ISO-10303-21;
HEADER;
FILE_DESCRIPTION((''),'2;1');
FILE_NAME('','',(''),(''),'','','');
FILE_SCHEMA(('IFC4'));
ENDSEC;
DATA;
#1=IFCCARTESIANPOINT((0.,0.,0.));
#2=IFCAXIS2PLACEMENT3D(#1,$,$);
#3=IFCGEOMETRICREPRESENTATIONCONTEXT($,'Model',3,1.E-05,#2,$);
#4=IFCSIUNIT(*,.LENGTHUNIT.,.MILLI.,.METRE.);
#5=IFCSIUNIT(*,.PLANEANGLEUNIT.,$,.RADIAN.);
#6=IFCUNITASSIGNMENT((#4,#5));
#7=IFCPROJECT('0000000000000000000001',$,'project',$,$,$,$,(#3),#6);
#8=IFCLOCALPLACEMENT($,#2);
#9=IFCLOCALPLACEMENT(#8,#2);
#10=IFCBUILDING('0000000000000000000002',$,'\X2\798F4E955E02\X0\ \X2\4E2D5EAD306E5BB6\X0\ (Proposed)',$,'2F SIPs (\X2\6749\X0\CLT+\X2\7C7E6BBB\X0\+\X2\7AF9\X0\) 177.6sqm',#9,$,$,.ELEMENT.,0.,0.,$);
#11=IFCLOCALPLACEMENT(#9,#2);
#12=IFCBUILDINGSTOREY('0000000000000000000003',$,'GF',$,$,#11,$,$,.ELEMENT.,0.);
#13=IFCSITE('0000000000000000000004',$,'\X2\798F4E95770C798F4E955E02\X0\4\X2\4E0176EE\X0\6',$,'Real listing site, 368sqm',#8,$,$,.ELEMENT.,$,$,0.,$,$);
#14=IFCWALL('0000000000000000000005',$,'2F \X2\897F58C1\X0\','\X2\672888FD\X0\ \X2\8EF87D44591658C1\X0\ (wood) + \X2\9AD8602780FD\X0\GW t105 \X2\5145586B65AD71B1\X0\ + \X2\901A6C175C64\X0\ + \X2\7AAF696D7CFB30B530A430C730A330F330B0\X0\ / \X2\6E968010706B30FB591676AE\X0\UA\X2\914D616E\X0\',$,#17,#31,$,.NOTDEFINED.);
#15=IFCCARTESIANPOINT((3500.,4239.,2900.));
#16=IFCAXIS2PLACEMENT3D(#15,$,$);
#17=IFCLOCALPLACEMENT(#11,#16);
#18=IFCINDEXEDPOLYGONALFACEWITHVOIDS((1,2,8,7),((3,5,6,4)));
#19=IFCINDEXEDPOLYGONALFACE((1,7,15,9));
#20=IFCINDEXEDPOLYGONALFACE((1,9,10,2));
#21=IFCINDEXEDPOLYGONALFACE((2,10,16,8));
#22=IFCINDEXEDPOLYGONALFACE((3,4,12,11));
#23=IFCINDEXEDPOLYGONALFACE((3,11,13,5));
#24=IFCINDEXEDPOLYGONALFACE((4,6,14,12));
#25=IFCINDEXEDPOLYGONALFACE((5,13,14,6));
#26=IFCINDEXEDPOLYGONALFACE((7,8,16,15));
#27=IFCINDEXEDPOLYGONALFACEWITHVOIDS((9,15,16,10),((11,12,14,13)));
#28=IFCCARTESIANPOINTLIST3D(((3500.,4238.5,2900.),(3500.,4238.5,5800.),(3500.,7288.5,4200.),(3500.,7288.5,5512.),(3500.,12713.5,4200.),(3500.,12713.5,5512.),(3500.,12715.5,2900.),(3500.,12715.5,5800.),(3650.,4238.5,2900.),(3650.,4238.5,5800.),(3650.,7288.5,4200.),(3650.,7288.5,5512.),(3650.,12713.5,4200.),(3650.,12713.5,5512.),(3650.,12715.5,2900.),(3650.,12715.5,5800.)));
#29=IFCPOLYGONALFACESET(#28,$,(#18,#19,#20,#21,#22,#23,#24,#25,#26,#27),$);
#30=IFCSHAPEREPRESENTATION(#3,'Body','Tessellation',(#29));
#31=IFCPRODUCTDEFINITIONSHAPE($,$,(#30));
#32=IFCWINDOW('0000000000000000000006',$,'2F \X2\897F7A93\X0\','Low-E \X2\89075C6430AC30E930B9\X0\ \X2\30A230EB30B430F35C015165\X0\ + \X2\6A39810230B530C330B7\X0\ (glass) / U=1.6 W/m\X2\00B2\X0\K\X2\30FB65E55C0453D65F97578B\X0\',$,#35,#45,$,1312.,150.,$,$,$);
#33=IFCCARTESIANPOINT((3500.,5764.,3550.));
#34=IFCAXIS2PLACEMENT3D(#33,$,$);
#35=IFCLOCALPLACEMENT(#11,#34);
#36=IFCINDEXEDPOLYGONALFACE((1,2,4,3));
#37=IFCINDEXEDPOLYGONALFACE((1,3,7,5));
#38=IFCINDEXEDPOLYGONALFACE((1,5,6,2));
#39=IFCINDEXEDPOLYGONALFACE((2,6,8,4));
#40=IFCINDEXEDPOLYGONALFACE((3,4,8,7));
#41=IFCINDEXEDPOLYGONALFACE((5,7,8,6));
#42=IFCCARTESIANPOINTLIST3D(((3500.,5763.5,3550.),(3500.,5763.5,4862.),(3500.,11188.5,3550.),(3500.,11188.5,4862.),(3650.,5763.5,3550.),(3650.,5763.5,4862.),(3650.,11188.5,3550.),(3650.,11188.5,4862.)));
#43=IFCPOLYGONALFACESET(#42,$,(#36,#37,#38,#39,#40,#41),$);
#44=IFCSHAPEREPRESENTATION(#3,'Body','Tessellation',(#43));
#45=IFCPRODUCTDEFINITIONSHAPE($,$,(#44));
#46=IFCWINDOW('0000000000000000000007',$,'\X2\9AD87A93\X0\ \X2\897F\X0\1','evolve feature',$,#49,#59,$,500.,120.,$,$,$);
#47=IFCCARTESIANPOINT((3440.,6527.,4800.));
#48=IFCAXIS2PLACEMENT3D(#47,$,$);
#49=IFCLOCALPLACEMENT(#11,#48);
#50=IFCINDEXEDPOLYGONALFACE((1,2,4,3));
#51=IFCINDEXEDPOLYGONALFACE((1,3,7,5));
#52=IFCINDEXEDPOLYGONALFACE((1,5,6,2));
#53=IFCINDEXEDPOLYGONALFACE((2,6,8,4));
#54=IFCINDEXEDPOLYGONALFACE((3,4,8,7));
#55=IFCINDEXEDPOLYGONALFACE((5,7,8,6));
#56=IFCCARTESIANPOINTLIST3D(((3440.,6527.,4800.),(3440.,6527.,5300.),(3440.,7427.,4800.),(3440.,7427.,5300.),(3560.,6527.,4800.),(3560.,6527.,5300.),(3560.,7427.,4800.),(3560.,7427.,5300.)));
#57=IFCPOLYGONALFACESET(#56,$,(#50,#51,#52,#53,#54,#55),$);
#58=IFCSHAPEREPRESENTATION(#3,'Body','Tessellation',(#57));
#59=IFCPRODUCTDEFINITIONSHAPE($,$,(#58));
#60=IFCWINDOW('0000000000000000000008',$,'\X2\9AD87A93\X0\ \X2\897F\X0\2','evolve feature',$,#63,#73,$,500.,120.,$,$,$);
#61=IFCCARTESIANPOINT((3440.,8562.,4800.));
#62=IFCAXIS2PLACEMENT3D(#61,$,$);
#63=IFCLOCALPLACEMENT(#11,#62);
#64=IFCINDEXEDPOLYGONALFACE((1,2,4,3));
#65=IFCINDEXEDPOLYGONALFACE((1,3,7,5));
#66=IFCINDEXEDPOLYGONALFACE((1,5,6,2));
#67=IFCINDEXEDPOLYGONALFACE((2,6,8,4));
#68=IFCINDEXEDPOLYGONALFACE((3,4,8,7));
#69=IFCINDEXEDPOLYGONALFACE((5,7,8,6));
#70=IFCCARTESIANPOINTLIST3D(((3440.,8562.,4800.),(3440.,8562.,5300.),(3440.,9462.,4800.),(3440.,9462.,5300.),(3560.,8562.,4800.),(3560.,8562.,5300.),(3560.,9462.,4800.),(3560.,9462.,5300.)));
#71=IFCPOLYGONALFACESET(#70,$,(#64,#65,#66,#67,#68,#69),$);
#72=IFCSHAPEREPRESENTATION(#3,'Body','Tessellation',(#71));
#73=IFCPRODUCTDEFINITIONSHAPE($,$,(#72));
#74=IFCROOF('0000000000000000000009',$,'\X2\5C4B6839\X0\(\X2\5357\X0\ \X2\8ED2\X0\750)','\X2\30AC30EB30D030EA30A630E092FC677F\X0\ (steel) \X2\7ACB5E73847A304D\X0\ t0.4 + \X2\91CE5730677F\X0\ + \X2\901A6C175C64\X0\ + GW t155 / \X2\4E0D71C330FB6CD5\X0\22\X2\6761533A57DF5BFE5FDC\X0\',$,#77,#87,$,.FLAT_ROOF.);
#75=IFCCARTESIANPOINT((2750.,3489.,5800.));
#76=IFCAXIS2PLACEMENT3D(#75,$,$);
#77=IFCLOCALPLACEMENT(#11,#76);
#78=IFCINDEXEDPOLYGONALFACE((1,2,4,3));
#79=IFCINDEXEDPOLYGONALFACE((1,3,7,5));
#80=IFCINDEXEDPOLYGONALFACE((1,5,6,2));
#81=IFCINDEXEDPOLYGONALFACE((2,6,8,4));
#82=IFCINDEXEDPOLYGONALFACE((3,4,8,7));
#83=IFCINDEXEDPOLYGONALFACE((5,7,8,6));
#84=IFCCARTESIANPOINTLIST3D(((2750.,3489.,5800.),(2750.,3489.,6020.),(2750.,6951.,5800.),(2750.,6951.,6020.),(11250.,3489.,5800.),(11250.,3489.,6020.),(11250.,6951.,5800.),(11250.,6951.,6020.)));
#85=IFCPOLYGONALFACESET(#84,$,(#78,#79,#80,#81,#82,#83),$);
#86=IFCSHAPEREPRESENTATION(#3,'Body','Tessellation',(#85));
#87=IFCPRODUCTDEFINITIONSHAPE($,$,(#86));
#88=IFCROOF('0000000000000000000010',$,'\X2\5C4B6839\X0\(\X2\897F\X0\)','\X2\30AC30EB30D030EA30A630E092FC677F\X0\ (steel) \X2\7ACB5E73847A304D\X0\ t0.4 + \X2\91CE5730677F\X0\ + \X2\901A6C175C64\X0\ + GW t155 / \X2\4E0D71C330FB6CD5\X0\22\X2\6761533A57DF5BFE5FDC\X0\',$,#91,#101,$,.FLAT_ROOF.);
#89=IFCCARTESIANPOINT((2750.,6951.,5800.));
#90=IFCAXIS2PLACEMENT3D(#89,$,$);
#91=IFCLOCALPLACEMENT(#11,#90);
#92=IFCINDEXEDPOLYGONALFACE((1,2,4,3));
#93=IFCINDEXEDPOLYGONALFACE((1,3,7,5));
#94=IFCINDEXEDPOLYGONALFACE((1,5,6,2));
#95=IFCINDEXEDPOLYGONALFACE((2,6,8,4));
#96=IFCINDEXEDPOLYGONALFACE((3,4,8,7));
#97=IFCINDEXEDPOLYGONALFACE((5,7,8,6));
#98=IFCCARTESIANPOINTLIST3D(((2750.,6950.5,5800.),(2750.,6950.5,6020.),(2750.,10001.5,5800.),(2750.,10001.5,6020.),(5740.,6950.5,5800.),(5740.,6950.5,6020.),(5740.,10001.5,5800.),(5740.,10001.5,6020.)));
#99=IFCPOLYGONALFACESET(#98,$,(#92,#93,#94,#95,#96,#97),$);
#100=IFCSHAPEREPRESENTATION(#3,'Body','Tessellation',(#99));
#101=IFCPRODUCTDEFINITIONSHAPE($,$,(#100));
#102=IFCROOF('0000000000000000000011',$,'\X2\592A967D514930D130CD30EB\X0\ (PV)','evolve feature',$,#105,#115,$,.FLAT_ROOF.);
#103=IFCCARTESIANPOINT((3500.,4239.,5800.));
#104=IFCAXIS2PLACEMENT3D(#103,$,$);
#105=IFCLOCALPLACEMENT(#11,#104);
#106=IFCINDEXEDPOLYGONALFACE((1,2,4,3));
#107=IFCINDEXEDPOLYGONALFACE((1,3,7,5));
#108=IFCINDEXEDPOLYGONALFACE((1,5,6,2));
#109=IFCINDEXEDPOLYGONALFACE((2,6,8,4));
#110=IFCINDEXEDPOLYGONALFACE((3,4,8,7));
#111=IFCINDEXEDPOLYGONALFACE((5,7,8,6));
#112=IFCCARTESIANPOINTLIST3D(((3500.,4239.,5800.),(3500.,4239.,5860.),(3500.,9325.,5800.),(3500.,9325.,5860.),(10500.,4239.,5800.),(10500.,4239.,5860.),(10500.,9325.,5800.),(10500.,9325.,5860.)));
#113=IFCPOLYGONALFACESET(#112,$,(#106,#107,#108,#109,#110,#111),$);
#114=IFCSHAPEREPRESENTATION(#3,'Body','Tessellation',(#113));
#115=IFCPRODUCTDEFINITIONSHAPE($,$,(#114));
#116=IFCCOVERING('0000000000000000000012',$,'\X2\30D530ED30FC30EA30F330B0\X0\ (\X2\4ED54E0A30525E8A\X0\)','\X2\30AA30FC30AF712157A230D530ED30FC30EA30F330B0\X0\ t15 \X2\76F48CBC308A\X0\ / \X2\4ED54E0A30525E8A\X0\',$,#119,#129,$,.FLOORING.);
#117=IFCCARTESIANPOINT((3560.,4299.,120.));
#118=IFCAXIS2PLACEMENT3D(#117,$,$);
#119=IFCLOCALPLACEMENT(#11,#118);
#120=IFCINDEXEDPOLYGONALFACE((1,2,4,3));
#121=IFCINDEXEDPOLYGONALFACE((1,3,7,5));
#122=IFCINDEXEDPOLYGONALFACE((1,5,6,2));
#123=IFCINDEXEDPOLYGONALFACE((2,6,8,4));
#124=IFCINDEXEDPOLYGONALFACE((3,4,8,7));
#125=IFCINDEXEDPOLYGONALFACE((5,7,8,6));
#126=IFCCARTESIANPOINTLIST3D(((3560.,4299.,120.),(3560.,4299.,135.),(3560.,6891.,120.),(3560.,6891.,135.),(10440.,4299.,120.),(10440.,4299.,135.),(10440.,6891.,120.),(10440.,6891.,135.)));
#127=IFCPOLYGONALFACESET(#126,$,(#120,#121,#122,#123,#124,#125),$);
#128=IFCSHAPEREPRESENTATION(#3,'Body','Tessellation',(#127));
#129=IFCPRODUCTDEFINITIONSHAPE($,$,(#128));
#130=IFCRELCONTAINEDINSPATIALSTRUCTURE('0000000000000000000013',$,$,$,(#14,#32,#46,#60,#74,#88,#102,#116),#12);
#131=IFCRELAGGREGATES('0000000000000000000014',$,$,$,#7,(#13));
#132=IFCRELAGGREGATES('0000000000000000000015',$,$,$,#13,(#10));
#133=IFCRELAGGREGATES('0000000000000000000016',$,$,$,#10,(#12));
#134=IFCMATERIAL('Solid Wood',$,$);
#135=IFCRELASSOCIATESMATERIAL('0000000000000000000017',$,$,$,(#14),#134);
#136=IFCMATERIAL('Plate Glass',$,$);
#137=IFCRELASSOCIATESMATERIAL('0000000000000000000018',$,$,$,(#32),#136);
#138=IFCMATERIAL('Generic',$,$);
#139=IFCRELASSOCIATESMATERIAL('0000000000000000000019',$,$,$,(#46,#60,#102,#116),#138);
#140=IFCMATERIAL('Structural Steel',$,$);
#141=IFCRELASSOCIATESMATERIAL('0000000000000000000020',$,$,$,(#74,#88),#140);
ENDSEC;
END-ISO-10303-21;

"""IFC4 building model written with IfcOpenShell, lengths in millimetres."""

from ifc_helpers import new_model, si_unit, frame, frame_2d, origin, place, context, project, spatial, rectangle, extrude, material, element, fill, save


model = new_model("IFC4")

# Units and contexts
model_context = context("Model", 3, precision=1e-05, world=origin())
ifc_project = project(units=[si_unit("LENGTHUNIT", "METRE", prefix="MILLI"), si_unit("PLANEANGLEUNIT", "RADIAN")], contexts=[model_context])

# Site, building, storey
site_placement = place(None, origin())
site = spatial("IfcSite", under=ifc_project, at=site_placement, Name="福井県福井市4丁目6", ObjectType="Real listing site, 368sqm", CompositionType="ELEMENT", RefElevation=0.0)
building_placement = place(site_placement, origin())
building = spatial("IfcBuilding", under=site, at=building_placement, Name="福井市 中庭の家 (Proposed)", ObjectType="2F SIPs (杉CLT+籾殻+竹) 177.6sqm", CompositionType="ELEMENT", ElevationOfRefHeight=0.0, ElevationOfTerrain=0.0)
storey_placement = place(building_placement, origin())
storey = spatial("IfcBuildingStorey", under=building, at=storey_placement, Name="GF", CompositionType="ELEMENT", Elevation=0.0)

# Shared definitions
ifc_material_1 = material(Name="Solid Wood")
ifc_material_2 = material(Name="Generic")

# Shared definitions
ifc_material_3 = material(Name="Plate Glass")

# Wall, openings, windows
wall_1_placement = place(storey_placement, frame((3500.0, 4239.0, 2900.0)))
wall_1 = element("IfcWall", 1, at=wall_1_placement, inside=storey, material=ifc_material_1, Name="2F 西壁", Description="木製 軸組外壁 (wood) + 高性能GW t105 充填断熱 + 通気層 + 窯業系サイディング / 準耐火・外皮UA配慮", PredefinedType="NOTDEFINED", context=model_context, shape_type="SweptSolid", body=[
    extrude(rectangle(XDim=150.0, YDim=8477.0, at=frame_2d((75.0, 4238.0))), frame((3500.0, 4239.0, 2900.0)), (0.0, 0.0, 1.0), 2900.0),
])
opening_1_placement = place(storey_placement, frame((3500.0, 5764.0, 3550.0)))
opening_1 = element("IfcOpeningElement", 2, at=opening_1_placement, cuts=wall_1, PredefinedType="NOTDEFINED", context=model_context, shape_type="SweptSolid", body=[
    extrude(rectangle(XDim=150.0, YDim=5425.0, at=frame_2d((75.0, 2712.0))), frame((3500.0, 5764.0, 3550.0)), (0.0, 0.0, 1.0), 1312.0),
])
opening_2_placement = place(storey_placement, frame((3440.0, 6527.0, 4800.0)))
opening_2 = element("IfcOpeningElement", 3, at=opening_2_placement, cuts=wall_1, PredefinedType="NOTDEFINED", context=model_context, shape_type="SweptSolid", body=[
    extrude(rectangle(XDim=120.0, YDim=900.0, at=frame_2d((60.0, 450.0))), frame((3440.0, 6527.0, 4800.0)), (0.0, 0.0, 1.0), 500.0),
])
opening_3_placement = place(storey_placement, frame((3440.0, 8562.0, 4800.0)))
opening_3 = element("IfcOpeningElement", 4, at=opening_3_placement, cuts=wall_1, PredefinedType="NOTDEFINED", context=model_context, shape_type="SweptSolid", body=[
    extrude(rectangle(XDim=120.0, YDim=900.0, at=frame_2d((60.0, 450.0))), frame((3440.0, 8562.0, 4800.0)), (0.0, 0.0, 1.0), 500.0),
])
window_1_placement = place(storey_placement, frame((3500.0, 5764.0, 3550.0)))
window_1 = element("IfcWindow", 5, at=window_1_placement, inside=storey, material=ifc_material_3, Name="2F 西窓", Description="Low-E 複層ガラス アルゴン封入 + 樹脂サッシ (glass) / U=1.6 W/m²K・日射取得型", OverallHeight=1312.0, OverallWidth=150.0, context=model_context, shape_type="SweptSolid", body=[
    extrude(rectangle(XDim=150.0, YDim=5425.0, at=frame_2d((75.0, 2712.0))), frame((3500.0, 5764.0, 3550.0)), (0.0, 0.0, 1.0), 1312.0),
])
fill(opening_1, window_1)
window_2_placement = place(storey_placement, frame((3440.0, 6527.0, 4800.0)))
window_2 = element("IfcWindow", 6, at=window_2_placement, inside=storey, material=ifc_material_2, Name="高窓 西1", Description="evolve feature", OverallHeight=500.0, OverallWidth=120.0, context=model_context, shape_type="SweptSolid", body=[
    extrude(rectangle(XDim=120.0, YDim=900.0, at=frame_2d((60.0, 450.0))), frame((3440.0, 6527.0, 4800.0)), (0.0, 0.0, 1.0), 500.0),
])
fill(opening_2, window_2)
window_3_placement = place(storey_placement, frame((3440.0, 8562.0, 4800.0)))
window_3 = element("IfcWindow", 7, at=window_3_placement, inside=storey, material=ifc_material_2, Name="高窓 西2", Description="evolve feature", OverallHeight=500.0, OverallWidth=120.0, context=model_context, shape_type="SweptSolid", body=[
    extrude(rectangle(XDim=120.0, YDim=900.0, at=frame_2d((60.0, 450.0))), frame((3440.0, 8562.0, 4800.0)), (0.0, 0.0, 1.0), 500.0),
])
fill(opening_3, window_3)

# Roofs
ifc_material_4 = material(Name="Structural Steel")
roof_1_placement = place(storey_placement, frame((2750.0, 3489.0, 5800.0)))
element("IfcRoof", 8, at=roof_1_placement, inside=storey, material=ifc_material_4, Name="屋根(南 軒750)", Description="ガルバリウム鋼板 (steel) 立平葺き t0.4 + 野地板 + 通気層 + GW t155 / 不燃・法22条区域対応", PredefinedType="FLAT_ROOF", context=model_context, shape_type="SweptSolid", body=[
    extrude(rectangle(XDim=8500.0, YDim=3462.0, at=frame_2d((4250.0, 1731.0))), frame((2750.0, 3489.0, 5800.0)), (0.0, 0.0, 1.0), 220.0),
])
roof_2_placement = place(storey_placement, frame((2750.0, 6951.0, 5800.0)))
element("IfcRoof", 9, at=roof_2_placement, inside=storey, material=ifc_material_4, Name="屋根(西)", Description="ガルバリウム鋼板 (steel) 立平葺き t0.4 + 野地板 + 通気層 + GW t155 / 不燃・法22条区域対応", PredefinedType="FLAT_ROOF", context=model_context, shape_type="SweptSolid", body=[
    extrude(rectangle(XDim=2990.0, YDim=3051.0, at=frame_2d((1495.0, 1525.0))), frame((2750.0, 6951.0, 5800.0)), (0.0, 0.0, 1.0), 220.0),
])
roof_3_placement = place(storey_placement, frame((3500.0, 4239.0, 5800.0)))
element("IfcRoof", 10, at=roof_3_placement, inside=storey, material=ifc_material_2, Name="太陽光パネル (PV)", Description="evolve feature", PredefinedType="FLAT_ROOF", context=model_context, shape_type="SweptSolid", body=[
    extrude(rectangle(XDim=7000.0, YDim=5086.0, at=frame_2d((3500.0, 2543.0))), frame((3500.0, 4239.0, 5800.0)), (0.0, 0.0, 1.0), 60.0),
])

# Covering
covering_placement = place(storey_placement, frame((3560.0, 4299.0, 120.0)))
element("IfcCovering", 11, at=covering_placement, inside=storey, material=ifc_material_2, Name="フローリング (仕上げ床)", Description="オーク無垢フローリング t15 直貼り / 仕上げ床", PredefinedType="FLOORING", context=model_context, shape_type="SweptSolid", body=[
    extrude(rectangle(XDim=6880.0, YDim=2592.0, at=frame_2d((3440.0, 1296.0))), frame((3560.0, 4299.0, 120.0)), (0.0, 0.0, 1.0), 15.0),
])

save(model, "model.ifc")
